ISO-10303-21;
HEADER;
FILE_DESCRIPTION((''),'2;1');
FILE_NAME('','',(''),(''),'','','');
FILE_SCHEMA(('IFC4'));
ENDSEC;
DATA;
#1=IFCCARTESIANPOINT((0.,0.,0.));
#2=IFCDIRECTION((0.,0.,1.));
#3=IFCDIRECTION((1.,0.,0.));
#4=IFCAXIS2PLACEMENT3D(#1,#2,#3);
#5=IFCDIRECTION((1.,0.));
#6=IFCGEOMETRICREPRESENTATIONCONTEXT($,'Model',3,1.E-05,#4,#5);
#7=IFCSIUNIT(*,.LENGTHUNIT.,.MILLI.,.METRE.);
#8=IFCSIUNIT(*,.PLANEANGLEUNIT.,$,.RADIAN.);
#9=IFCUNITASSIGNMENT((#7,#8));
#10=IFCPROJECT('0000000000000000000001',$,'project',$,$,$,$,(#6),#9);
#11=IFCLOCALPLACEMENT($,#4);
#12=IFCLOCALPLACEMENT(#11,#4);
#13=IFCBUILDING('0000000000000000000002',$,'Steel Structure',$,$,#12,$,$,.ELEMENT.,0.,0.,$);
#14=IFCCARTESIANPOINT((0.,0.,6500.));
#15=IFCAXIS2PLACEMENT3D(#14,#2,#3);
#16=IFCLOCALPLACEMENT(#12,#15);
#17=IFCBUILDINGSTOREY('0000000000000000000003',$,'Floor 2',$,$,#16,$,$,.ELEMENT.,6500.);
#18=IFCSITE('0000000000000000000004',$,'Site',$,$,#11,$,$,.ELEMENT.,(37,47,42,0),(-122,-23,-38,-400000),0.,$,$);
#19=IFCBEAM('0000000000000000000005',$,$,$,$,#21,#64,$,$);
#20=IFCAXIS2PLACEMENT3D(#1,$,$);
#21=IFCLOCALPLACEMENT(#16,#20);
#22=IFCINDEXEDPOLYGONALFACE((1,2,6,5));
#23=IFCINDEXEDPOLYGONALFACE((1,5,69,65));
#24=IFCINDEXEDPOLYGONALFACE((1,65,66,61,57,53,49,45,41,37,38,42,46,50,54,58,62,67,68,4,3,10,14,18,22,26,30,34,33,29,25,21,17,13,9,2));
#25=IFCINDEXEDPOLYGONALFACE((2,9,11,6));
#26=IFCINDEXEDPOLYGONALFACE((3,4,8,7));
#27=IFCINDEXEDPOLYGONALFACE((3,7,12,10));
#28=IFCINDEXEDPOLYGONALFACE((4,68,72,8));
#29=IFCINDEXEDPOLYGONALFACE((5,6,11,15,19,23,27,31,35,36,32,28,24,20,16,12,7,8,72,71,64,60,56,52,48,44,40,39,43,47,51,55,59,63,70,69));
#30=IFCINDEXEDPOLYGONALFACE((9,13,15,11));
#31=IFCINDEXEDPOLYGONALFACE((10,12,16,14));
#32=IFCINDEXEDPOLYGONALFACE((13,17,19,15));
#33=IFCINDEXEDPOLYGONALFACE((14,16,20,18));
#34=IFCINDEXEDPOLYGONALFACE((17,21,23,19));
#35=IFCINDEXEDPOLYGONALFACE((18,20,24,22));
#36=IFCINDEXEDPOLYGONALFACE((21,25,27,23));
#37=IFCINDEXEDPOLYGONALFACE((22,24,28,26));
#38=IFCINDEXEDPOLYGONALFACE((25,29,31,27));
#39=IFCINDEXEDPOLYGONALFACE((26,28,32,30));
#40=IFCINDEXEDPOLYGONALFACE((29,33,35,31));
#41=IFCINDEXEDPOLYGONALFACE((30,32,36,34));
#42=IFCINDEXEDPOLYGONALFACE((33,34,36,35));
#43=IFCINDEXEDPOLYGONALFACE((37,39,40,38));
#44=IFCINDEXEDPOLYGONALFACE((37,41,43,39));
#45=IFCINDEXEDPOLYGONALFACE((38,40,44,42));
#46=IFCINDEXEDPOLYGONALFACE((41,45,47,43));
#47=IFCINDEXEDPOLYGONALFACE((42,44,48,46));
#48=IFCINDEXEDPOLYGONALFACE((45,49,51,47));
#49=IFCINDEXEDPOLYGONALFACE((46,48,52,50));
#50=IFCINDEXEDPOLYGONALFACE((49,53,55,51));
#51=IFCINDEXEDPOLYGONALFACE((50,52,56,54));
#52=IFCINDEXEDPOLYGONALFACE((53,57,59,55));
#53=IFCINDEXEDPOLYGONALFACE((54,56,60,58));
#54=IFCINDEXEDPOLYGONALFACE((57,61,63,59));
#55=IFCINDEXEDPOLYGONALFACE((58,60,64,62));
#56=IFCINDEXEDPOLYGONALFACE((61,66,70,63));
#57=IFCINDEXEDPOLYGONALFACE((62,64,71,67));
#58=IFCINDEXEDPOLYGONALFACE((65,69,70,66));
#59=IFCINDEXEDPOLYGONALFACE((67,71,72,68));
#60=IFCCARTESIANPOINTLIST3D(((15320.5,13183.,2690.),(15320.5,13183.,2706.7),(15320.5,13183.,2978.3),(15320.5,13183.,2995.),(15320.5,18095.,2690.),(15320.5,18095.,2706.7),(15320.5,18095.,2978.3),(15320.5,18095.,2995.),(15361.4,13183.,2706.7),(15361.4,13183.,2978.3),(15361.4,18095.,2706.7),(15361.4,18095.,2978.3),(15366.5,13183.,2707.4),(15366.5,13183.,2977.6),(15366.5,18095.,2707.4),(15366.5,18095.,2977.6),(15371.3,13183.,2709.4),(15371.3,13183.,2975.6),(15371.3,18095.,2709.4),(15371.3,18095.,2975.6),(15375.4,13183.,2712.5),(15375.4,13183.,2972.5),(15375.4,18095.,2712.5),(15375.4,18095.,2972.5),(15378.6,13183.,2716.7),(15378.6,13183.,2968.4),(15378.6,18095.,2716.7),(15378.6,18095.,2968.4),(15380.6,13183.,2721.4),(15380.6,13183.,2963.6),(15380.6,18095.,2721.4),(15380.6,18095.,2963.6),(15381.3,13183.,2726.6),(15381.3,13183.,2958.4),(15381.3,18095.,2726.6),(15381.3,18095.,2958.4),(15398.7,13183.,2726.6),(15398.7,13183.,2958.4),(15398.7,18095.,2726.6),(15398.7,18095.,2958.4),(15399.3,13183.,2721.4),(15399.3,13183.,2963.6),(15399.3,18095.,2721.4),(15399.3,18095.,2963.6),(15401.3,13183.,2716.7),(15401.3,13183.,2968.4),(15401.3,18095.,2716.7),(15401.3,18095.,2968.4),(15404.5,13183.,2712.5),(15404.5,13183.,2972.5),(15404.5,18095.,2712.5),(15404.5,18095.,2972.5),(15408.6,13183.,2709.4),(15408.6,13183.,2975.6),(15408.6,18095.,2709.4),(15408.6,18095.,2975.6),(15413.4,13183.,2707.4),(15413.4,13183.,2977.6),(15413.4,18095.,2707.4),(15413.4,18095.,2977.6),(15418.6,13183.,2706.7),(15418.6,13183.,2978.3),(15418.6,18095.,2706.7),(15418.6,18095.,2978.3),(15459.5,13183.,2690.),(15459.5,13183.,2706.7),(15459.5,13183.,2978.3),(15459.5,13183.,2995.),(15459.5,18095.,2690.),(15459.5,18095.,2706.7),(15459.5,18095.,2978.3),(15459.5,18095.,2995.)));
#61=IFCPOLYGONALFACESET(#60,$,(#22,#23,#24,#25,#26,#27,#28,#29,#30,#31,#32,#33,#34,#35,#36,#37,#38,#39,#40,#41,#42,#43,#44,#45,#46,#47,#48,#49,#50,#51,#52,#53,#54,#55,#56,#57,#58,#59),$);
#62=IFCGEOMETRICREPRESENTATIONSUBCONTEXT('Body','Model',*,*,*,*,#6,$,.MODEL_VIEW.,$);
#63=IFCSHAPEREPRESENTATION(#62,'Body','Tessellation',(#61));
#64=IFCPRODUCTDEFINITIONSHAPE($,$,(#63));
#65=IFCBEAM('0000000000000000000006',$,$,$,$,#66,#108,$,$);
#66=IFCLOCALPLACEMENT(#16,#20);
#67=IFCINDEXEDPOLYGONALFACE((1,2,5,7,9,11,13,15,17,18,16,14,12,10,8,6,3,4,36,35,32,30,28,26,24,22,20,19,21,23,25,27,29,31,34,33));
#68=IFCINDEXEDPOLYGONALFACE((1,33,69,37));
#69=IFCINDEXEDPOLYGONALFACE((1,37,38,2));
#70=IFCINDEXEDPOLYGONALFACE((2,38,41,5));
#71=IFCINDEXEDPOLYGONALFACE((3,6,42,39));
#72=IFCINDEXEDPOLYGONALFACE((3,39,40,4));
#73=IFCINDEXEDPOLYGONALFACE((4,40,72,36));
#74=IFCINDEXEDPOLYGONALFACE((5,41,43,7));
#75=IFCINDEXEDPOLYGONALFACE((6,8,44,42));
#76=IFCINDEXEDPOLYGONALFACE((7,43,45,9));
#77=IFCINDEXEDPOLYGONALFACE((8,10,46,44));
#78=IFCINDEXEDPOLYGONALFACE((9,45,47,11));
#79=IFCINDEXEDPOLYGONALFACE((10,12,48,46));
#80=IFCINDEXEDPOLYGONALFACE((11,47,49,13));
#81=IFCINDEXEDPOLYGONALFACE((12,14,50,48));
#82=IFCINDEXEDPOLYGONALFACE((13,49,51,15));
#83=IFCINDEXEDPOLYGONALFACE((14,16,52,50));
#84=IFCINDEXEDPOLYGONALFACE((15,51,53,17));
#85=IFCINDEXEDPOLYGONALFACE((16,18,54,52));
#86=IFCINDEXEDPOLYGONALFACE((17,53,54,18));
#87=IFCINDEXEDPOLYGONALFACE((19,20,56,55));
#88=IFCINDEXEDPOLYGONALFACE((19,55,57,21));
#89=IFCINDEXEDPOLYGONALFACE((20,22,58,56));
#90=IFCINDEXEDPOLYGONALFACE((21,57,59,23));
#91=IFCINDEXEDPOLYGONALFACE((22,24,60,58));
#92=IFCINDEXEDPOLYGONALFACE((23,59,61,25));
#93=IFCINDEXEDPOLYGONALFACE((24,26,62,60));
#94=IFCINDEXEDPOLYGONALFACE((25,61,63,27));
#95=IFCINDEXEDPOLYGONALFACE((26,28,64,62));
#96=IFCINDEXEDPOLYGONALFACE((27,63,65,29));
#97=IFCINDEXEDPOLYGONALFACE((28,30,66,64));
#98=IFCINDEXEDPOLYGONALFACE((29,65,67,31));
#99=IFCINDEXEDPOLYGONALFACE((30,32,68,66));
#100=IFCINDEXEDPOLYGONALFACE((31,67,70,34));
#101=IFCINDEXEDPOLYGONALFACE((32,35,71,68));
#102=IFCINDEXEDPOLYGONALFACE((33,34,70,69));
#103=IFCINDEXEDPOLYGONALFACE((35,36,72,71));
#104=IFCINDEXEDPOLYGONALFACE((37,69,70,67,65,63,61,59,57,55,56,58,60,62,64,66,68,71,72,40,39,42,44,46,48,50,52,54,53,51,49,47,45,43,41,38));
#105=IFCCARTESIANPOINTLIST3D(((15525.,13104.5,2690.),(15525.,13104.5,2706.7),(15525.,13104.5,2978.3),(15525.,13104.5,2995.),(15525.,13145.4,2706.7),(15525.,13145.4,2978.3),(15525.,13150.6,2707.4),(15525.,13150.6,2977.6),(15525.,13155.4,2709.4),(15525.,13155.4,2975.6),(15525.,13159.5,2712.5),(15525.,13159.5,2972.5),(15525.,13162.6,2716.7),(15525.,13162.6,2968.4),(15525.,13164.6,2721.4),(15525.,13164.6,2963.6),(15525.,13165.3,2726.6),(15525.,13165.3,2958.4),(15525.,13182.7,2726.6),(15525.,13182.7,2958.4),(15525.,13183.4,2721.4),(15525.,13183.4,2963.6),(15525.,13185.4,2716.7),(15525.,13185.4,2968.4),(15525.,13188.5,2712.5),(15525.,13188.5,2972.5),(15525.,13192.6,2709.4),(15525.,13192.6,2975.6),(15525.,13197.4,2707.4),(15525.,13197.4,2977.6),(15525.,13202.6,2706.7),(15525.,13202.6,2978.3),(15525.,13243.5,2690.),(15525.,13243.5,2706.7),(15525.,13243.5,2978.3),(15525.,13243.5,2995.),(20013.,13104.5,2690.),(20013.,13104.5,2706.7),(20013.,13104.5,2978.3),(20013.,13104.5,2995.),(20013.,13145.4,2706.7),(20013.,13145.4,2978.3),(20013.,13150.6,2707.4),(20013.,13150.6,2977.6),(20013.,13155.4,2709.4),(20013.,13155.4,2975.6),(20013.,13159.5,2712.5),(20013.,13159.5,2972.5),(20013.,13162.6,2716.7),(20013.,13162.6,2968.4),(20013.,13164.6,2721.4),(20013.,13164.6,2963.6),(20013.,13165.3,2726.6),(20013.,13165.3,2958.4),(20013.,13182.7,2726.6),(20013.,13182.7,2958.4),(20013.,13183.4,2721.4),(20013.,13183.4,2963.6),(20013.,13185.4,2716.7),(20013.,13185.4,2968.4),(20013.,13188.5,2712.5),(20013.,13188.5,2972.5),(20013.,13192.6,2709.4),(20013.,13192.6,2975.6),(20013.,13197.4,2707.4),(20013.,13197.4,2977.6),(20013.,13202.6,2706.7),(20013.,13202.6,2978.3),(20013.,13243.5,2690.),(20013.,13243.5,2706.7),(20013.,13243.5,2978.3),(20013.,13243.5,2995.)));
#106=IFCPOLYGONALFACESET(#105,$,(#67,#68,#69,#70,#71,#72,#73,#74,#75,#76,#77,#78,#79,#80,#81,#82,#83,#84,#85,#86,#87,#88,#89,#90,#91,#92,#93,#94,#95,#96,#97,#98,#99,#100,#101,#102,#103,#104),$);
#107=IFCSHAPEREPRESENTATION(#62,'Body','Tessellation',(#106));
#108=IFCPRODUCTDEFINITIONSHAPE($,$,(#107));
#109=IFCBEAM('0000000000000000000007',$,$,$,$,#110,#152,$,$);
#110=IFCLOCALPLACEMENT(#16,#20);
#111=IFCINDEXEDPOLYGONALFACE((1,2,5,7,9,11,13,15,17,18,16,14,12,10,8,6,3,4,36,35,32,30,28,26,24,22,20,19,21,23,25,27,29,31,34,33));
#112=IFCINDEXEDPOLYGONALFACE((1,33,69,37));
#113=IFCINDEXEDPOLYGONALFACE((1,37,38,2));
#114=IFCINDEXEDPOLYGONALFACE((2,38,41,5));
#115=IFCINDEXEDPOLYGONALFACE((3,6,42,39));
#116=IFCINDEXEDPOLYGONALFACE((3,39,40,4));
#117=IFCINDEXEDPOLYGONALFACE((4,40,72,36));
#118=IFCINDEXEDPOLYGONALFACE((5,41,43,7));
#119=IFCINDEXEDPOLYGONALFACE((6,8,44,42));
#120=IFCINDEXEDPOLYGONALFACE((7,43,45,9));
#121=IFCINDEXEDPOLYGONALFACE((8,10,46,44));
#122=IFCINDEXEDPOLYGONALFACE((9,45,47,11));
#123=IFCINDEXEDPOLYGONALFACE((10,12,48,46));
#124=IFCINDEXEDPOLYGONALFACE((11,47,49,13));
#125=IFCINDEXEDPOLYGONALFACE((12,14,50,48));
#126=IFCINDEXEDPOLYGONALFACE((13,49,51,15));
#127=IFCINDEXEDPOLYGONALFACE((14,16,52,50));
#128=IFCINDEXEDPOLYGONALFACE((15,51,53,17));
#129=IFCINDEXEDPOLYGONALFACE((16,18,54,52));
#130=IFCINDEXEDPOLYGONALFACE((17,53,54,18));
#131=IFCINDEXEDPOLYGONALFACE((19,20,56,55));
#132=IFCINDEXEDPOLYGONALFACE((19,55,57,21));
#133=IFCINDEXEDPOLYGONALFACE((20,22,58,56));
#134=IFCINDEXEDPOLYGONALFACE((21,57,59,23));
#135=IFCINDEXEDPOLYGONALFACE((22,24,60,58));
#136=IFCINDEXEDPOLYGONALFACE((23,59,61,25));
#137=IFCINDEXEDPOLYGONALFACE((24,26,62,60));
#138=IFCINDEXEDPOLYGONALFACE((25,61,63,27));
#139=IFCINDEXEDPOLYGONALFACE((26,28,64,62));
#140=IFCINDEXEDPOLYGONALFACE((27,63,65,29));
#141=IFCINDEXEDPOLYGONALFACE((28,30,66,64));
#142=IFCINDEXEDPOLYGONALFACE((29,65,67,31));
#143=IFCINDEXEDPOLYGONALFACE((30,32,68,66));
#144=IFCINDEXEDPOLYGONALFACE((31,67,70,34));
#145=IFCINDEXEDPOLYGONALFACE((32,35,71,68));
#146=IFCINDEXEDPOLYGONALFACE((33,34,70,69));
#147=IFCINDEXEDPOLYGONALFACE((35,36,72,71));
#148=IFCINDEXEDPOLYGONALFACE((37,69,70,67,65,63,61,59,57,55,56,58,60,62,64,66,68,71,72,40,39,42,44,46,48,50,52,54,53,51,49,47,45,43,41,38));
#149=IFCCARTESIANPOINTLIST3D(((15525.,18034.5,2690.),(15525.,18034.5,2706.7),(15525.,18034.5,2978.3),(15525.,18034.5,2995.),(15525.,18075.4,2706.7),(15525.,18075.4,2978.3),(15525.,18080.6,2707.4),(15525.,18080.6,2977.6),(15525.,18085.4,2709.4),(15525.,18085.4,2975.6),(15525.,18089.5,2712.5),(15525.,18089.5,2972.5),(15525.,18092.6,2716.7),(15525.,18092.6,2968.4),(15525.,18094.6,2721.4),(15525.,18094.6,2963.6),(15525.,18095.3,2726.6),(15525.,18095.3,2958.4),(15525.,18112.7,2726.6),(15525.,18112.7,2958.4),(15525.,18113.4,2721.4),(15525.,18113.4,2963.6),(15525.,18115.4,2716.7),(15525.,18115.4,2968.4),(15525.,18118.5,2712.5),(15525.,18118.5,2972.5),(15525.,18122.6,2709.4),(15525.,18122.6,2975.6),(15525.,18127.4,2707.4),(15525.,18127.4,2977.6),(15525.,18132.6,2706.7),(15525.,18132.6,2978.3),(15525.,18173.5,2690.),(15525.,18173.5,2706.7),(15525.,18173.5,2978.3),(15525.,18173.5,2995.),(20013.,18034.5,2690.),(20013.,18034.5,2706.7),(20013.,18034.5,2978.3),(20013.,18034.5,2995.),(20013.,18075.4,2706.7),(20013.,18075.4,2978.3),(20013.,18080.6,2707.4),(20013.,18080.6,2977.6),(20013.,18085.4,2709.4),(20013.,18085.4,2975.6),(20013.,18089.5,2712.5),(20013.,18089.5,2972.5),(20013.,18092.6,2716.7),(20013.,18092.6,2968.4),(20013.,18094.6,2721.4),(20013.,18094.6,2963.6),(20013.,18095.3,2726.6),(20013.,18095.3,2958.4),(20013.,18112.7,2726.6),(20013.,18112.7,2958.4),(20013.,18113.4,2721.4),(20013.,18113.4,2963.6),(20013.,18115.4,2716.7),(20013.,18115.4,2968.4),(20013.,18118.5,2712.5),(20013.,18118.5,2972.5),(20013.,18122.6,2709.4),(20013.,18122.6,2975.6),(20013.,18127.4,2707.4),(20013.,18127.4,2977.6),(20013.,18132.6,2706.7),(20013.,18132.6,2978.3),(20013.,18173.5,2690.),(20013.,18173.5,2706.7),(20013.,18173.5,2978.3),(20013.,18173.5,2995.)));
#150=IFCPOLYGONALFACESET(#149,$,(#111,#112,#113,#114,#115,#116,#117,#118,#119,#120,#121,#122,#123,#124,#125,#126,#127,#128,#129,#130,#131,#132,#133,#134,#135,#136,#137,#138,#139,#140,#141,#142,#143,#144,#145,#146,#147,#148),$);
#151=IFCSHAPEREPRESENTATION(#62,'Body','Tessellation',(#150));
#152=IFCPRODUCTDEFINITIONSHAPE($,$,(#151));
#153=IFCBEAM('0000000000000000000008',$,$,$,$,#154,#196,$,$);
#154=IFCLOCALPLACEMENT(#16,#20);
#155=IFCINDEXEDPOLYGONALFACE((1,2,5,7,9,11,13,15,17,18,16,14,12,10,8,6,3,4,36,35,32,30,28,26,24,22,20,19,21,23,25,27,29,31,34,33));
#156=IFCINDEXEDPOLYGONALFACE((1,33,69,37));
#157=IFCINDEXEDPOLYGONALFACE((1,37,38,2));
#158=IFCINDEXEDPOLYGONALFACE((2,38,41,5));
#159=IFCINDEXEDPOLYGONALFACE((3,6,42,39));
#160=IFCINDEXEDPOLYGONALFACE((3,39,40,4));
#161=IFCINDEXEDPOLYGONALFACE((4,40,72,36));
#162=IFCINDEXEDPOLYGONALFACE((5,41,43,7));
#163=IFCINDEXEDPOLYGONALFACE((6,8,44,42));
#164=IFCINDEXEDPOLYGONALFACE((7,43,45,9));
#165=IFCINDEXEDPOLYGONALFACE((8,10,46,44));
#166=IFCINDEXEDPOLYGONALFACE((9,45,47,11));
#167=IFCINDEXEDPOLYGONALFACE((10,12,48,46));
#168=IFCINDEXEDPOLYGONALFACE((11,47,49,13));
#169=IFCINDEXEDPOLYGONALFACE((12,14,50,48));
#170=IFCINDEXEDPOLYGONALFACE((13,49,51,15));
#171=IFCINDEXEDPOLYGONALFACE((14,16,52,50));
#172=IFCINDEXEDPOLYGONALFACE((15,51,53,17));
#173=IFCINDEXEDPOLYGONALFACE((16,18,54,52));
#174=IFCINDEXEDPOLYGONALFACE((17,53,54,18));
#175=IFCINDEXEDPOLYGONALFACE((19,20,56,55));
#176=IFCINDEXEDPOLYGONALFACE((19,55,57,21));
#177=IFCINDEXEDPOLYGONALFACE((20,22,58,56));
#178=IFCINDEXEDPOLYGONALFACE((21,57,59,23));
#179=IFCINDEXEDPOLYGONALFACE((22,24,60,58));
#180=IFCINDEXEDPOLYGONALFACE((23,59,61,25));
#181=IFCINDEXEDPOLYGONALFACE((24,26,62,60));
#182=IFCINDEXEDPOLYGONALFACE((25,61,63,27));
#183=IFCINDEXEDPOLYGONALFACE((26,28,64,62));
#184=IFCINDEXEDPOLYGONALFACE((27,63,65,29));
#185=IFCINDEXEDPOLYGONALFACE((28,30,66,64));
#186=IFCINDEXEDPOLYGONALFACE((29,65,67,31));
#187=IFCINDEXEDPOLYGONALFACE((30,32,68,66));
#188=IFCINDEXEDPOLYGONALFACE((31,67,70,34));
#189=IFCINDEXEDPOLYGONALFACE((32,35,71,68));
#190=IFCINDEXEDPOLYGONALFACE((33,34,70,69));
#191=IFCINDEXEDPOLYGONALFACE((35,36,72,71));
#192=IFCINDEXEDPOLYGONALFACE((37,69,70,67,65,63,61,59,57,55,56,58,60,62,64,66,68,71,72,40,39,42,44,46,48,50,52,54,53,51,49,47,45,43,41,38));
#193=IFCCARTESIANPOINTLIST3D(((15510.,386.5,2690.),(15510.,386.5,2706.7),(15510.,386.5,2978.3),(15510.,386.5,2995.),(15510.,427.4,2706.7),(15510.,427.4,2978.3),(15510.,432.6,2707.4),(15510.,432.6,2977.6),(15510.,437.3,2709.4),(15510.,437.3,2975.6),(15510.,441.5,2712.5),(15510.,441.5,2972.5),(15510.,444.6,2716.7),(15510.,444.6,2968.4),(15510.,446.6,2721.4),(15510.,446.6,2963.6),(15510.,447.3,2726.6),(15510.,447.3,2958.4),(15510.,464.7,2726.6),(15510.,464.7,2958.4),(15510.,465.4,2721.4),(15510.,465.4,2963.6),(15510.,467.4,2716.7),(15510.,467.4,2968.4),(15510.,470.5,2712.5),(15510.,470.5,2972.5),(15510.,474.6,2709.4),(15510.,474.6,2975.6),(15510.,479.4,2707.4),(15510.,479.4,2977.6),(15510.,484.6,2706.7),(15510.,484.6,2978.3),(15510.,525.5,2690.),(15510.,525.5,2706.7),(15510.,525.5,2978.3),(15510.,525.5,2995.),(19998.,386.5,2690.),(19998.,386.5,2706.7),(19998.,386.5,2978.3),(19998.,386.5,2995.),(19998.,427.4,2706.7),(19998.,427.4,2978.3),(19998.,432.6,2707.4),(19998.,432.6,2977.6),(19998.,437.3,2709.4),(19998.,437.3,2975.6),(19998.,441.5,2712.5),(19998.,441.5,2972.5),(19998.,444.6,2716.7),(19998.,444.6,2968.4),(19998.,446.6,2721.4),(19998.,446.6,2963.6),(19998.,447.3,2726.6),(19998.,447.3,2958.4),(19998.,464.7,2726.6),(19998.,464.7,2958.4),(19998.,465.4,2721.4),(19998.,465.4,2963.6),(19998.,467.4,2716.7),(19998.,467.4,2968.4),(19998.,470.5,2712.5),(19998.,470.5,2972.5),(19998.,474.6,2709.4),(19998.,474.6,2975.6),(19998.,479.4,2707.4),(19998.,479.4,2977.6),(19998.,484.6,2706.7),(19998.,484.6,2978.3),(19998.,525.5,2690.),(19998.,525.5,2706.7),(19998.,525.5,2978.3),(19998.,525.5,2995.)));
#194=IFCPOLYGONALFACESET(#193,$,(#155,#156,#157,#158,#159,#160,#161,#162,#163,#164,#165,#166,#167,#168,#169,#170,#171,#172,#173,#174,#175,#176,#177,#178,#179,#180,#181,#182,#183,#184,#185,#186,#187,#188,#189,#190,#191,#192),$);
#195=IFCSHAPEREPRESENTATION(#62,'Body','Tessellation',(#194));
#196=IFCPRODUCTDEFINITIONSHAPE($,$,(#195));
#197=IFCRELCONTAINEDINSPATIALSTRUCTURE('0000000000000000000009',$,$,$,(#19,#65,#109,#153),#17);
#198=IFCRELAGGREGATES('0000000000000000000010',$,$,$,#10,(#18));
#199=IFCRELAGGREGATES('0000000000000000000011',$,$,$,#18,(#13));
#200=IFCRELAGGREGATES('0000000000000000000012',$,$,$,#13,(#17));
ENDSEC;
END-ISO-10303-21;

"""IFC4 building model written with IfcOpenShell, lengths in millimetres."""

from ifc_helpers import new_model, si_unit, direction, frame, origin_with_axes, origin_2d_with_axis, place, context, subcontext, project, spatial, i_section, extrude, element, save


model = new_model("IFC4")

# Units and contexts
model_context = context("Model", 3, precision=1e-05, world=origin_with_axes(), true_north=direction((1.0, 0.0)))
body_context = subcontext(model_context, "Body", "Model", "MODEL_VIEW")
ifc_project = project(units=[si_unit("LENGTHUNIT", "METRE", prefix="MILLI"), si_unit("PLANEANGLEUNIT", "RADIAN")], contexts=[model_context])

# Site, building, storey
site_placement = place(None, origin_with_axes())
site = spatial("IfcSite", under=ifc_project, at=site_placement, Name="Site", CompositionType="ELEMENT", RefLatitude=(37, 47, 42, 0), RefLongitude=(-122, -23, -38, -400000), RefElevation=0.0)
building_placement = place(site_placement, origin_with_axes())
building = spatial("IfcBuilding", under=site, at=building_placement, Name="Steel Structure", CompositionType="ELEMENT", ElevationOfRefHeight=0.0, ElevationOfTerrain=0.0)
storey_placement = place(building_placement, frame((0.0, 0.0, 6500.0), z_axis=(0.0, 0.0, 1.0), x_axis=(1.0, 0.0, 0.0)))
storey = spatial("IfcBuildingStorey", under=building, at=storey_placement, Name="Floor 2", CompositionType="ELEMENT", Elevation=6500.0)

# Beams
beam_1_placement = place(storey_placement, frame((15390.0, 18095.0, 2690.0), z_axis=(0.0, -1.0, 0.0), x_axis=(1.0, 0.0, 0.0)))
element("IfcBeam", 1, at=beam_1_placement, inside=storey, context=body_context, shape_type="SweptSolid", body=[
    extrude(i_section(OverallWidth=139.0, OverallDepth=305.0, WebThickness=17.4, FlangeThickness=16.7, FilletRadius=19.9, at=origin_2d_with_axis()), frame((0.0, 152.5, 0.0), z_axis=(0.0, 0.0, 1.0), x_axis=(1.0, 0.0, 0.0)), (0.0, 0.0, 1.0), 4912.0),
])
beam_2_placement = place(storey_placement, frame((15525.0, 13174.0, 2690.0), z_axis=(1.0, 0.0, 0.0), x_axis=(0.0, 1.0, 0.0)))
element("IfcBeam", 2, at=beam_2_placement, inside=storey, context=body_context, shape_type="SweptSolid", body=[
    extrude(i_section(OverallWidth=139.0, OverallDepth=305.0, WebThickness=17.4, FlangeThickness=16.7, FilletRadius=19.9, at=origin_2d_with_axis()), frame((0.0, 152.5, 0.0), z_axis=(0.0, 0.0, 1.0), x_axis=(1.0, 0.0, 0.0)), (0.0, 0.0, 1.0), 4488.0),
])
for number, where, z_axis, x_axis in (
    (3, (20013.0, 18104.0, 2690.0), (-1.0, 0.0, 0.0), (0.0, -1.0, 0.0)),
    (4, (19998.0, 456.0, 2690.0), (-1.0, 0.0, 0.0), (0.0, -1.0, 0.0)),
):
    element("IfcBeam", number, at=place(storey_placement, frame(where, z_axis=z_axis, x_axis=x_axis)), inside=storey, context=body_context, shape_type="SweptSolid", body=[
        extrude(i_section(OverallWidth=139.0, OverallDepth=305.0, WebThickness=17.4, FlangeThickness=16.7, FilletRadius=19.9, at=origin_2d_with_axis()), frame((0.0, 152.5, 0.0), z_axis=(0.0, 0.0, 1.0), x_axis=(1.0, 0.0, 0.0)), (0.0, 0.0, 1.0), 4488.0),
    ])

save(model, "model.ifc")
